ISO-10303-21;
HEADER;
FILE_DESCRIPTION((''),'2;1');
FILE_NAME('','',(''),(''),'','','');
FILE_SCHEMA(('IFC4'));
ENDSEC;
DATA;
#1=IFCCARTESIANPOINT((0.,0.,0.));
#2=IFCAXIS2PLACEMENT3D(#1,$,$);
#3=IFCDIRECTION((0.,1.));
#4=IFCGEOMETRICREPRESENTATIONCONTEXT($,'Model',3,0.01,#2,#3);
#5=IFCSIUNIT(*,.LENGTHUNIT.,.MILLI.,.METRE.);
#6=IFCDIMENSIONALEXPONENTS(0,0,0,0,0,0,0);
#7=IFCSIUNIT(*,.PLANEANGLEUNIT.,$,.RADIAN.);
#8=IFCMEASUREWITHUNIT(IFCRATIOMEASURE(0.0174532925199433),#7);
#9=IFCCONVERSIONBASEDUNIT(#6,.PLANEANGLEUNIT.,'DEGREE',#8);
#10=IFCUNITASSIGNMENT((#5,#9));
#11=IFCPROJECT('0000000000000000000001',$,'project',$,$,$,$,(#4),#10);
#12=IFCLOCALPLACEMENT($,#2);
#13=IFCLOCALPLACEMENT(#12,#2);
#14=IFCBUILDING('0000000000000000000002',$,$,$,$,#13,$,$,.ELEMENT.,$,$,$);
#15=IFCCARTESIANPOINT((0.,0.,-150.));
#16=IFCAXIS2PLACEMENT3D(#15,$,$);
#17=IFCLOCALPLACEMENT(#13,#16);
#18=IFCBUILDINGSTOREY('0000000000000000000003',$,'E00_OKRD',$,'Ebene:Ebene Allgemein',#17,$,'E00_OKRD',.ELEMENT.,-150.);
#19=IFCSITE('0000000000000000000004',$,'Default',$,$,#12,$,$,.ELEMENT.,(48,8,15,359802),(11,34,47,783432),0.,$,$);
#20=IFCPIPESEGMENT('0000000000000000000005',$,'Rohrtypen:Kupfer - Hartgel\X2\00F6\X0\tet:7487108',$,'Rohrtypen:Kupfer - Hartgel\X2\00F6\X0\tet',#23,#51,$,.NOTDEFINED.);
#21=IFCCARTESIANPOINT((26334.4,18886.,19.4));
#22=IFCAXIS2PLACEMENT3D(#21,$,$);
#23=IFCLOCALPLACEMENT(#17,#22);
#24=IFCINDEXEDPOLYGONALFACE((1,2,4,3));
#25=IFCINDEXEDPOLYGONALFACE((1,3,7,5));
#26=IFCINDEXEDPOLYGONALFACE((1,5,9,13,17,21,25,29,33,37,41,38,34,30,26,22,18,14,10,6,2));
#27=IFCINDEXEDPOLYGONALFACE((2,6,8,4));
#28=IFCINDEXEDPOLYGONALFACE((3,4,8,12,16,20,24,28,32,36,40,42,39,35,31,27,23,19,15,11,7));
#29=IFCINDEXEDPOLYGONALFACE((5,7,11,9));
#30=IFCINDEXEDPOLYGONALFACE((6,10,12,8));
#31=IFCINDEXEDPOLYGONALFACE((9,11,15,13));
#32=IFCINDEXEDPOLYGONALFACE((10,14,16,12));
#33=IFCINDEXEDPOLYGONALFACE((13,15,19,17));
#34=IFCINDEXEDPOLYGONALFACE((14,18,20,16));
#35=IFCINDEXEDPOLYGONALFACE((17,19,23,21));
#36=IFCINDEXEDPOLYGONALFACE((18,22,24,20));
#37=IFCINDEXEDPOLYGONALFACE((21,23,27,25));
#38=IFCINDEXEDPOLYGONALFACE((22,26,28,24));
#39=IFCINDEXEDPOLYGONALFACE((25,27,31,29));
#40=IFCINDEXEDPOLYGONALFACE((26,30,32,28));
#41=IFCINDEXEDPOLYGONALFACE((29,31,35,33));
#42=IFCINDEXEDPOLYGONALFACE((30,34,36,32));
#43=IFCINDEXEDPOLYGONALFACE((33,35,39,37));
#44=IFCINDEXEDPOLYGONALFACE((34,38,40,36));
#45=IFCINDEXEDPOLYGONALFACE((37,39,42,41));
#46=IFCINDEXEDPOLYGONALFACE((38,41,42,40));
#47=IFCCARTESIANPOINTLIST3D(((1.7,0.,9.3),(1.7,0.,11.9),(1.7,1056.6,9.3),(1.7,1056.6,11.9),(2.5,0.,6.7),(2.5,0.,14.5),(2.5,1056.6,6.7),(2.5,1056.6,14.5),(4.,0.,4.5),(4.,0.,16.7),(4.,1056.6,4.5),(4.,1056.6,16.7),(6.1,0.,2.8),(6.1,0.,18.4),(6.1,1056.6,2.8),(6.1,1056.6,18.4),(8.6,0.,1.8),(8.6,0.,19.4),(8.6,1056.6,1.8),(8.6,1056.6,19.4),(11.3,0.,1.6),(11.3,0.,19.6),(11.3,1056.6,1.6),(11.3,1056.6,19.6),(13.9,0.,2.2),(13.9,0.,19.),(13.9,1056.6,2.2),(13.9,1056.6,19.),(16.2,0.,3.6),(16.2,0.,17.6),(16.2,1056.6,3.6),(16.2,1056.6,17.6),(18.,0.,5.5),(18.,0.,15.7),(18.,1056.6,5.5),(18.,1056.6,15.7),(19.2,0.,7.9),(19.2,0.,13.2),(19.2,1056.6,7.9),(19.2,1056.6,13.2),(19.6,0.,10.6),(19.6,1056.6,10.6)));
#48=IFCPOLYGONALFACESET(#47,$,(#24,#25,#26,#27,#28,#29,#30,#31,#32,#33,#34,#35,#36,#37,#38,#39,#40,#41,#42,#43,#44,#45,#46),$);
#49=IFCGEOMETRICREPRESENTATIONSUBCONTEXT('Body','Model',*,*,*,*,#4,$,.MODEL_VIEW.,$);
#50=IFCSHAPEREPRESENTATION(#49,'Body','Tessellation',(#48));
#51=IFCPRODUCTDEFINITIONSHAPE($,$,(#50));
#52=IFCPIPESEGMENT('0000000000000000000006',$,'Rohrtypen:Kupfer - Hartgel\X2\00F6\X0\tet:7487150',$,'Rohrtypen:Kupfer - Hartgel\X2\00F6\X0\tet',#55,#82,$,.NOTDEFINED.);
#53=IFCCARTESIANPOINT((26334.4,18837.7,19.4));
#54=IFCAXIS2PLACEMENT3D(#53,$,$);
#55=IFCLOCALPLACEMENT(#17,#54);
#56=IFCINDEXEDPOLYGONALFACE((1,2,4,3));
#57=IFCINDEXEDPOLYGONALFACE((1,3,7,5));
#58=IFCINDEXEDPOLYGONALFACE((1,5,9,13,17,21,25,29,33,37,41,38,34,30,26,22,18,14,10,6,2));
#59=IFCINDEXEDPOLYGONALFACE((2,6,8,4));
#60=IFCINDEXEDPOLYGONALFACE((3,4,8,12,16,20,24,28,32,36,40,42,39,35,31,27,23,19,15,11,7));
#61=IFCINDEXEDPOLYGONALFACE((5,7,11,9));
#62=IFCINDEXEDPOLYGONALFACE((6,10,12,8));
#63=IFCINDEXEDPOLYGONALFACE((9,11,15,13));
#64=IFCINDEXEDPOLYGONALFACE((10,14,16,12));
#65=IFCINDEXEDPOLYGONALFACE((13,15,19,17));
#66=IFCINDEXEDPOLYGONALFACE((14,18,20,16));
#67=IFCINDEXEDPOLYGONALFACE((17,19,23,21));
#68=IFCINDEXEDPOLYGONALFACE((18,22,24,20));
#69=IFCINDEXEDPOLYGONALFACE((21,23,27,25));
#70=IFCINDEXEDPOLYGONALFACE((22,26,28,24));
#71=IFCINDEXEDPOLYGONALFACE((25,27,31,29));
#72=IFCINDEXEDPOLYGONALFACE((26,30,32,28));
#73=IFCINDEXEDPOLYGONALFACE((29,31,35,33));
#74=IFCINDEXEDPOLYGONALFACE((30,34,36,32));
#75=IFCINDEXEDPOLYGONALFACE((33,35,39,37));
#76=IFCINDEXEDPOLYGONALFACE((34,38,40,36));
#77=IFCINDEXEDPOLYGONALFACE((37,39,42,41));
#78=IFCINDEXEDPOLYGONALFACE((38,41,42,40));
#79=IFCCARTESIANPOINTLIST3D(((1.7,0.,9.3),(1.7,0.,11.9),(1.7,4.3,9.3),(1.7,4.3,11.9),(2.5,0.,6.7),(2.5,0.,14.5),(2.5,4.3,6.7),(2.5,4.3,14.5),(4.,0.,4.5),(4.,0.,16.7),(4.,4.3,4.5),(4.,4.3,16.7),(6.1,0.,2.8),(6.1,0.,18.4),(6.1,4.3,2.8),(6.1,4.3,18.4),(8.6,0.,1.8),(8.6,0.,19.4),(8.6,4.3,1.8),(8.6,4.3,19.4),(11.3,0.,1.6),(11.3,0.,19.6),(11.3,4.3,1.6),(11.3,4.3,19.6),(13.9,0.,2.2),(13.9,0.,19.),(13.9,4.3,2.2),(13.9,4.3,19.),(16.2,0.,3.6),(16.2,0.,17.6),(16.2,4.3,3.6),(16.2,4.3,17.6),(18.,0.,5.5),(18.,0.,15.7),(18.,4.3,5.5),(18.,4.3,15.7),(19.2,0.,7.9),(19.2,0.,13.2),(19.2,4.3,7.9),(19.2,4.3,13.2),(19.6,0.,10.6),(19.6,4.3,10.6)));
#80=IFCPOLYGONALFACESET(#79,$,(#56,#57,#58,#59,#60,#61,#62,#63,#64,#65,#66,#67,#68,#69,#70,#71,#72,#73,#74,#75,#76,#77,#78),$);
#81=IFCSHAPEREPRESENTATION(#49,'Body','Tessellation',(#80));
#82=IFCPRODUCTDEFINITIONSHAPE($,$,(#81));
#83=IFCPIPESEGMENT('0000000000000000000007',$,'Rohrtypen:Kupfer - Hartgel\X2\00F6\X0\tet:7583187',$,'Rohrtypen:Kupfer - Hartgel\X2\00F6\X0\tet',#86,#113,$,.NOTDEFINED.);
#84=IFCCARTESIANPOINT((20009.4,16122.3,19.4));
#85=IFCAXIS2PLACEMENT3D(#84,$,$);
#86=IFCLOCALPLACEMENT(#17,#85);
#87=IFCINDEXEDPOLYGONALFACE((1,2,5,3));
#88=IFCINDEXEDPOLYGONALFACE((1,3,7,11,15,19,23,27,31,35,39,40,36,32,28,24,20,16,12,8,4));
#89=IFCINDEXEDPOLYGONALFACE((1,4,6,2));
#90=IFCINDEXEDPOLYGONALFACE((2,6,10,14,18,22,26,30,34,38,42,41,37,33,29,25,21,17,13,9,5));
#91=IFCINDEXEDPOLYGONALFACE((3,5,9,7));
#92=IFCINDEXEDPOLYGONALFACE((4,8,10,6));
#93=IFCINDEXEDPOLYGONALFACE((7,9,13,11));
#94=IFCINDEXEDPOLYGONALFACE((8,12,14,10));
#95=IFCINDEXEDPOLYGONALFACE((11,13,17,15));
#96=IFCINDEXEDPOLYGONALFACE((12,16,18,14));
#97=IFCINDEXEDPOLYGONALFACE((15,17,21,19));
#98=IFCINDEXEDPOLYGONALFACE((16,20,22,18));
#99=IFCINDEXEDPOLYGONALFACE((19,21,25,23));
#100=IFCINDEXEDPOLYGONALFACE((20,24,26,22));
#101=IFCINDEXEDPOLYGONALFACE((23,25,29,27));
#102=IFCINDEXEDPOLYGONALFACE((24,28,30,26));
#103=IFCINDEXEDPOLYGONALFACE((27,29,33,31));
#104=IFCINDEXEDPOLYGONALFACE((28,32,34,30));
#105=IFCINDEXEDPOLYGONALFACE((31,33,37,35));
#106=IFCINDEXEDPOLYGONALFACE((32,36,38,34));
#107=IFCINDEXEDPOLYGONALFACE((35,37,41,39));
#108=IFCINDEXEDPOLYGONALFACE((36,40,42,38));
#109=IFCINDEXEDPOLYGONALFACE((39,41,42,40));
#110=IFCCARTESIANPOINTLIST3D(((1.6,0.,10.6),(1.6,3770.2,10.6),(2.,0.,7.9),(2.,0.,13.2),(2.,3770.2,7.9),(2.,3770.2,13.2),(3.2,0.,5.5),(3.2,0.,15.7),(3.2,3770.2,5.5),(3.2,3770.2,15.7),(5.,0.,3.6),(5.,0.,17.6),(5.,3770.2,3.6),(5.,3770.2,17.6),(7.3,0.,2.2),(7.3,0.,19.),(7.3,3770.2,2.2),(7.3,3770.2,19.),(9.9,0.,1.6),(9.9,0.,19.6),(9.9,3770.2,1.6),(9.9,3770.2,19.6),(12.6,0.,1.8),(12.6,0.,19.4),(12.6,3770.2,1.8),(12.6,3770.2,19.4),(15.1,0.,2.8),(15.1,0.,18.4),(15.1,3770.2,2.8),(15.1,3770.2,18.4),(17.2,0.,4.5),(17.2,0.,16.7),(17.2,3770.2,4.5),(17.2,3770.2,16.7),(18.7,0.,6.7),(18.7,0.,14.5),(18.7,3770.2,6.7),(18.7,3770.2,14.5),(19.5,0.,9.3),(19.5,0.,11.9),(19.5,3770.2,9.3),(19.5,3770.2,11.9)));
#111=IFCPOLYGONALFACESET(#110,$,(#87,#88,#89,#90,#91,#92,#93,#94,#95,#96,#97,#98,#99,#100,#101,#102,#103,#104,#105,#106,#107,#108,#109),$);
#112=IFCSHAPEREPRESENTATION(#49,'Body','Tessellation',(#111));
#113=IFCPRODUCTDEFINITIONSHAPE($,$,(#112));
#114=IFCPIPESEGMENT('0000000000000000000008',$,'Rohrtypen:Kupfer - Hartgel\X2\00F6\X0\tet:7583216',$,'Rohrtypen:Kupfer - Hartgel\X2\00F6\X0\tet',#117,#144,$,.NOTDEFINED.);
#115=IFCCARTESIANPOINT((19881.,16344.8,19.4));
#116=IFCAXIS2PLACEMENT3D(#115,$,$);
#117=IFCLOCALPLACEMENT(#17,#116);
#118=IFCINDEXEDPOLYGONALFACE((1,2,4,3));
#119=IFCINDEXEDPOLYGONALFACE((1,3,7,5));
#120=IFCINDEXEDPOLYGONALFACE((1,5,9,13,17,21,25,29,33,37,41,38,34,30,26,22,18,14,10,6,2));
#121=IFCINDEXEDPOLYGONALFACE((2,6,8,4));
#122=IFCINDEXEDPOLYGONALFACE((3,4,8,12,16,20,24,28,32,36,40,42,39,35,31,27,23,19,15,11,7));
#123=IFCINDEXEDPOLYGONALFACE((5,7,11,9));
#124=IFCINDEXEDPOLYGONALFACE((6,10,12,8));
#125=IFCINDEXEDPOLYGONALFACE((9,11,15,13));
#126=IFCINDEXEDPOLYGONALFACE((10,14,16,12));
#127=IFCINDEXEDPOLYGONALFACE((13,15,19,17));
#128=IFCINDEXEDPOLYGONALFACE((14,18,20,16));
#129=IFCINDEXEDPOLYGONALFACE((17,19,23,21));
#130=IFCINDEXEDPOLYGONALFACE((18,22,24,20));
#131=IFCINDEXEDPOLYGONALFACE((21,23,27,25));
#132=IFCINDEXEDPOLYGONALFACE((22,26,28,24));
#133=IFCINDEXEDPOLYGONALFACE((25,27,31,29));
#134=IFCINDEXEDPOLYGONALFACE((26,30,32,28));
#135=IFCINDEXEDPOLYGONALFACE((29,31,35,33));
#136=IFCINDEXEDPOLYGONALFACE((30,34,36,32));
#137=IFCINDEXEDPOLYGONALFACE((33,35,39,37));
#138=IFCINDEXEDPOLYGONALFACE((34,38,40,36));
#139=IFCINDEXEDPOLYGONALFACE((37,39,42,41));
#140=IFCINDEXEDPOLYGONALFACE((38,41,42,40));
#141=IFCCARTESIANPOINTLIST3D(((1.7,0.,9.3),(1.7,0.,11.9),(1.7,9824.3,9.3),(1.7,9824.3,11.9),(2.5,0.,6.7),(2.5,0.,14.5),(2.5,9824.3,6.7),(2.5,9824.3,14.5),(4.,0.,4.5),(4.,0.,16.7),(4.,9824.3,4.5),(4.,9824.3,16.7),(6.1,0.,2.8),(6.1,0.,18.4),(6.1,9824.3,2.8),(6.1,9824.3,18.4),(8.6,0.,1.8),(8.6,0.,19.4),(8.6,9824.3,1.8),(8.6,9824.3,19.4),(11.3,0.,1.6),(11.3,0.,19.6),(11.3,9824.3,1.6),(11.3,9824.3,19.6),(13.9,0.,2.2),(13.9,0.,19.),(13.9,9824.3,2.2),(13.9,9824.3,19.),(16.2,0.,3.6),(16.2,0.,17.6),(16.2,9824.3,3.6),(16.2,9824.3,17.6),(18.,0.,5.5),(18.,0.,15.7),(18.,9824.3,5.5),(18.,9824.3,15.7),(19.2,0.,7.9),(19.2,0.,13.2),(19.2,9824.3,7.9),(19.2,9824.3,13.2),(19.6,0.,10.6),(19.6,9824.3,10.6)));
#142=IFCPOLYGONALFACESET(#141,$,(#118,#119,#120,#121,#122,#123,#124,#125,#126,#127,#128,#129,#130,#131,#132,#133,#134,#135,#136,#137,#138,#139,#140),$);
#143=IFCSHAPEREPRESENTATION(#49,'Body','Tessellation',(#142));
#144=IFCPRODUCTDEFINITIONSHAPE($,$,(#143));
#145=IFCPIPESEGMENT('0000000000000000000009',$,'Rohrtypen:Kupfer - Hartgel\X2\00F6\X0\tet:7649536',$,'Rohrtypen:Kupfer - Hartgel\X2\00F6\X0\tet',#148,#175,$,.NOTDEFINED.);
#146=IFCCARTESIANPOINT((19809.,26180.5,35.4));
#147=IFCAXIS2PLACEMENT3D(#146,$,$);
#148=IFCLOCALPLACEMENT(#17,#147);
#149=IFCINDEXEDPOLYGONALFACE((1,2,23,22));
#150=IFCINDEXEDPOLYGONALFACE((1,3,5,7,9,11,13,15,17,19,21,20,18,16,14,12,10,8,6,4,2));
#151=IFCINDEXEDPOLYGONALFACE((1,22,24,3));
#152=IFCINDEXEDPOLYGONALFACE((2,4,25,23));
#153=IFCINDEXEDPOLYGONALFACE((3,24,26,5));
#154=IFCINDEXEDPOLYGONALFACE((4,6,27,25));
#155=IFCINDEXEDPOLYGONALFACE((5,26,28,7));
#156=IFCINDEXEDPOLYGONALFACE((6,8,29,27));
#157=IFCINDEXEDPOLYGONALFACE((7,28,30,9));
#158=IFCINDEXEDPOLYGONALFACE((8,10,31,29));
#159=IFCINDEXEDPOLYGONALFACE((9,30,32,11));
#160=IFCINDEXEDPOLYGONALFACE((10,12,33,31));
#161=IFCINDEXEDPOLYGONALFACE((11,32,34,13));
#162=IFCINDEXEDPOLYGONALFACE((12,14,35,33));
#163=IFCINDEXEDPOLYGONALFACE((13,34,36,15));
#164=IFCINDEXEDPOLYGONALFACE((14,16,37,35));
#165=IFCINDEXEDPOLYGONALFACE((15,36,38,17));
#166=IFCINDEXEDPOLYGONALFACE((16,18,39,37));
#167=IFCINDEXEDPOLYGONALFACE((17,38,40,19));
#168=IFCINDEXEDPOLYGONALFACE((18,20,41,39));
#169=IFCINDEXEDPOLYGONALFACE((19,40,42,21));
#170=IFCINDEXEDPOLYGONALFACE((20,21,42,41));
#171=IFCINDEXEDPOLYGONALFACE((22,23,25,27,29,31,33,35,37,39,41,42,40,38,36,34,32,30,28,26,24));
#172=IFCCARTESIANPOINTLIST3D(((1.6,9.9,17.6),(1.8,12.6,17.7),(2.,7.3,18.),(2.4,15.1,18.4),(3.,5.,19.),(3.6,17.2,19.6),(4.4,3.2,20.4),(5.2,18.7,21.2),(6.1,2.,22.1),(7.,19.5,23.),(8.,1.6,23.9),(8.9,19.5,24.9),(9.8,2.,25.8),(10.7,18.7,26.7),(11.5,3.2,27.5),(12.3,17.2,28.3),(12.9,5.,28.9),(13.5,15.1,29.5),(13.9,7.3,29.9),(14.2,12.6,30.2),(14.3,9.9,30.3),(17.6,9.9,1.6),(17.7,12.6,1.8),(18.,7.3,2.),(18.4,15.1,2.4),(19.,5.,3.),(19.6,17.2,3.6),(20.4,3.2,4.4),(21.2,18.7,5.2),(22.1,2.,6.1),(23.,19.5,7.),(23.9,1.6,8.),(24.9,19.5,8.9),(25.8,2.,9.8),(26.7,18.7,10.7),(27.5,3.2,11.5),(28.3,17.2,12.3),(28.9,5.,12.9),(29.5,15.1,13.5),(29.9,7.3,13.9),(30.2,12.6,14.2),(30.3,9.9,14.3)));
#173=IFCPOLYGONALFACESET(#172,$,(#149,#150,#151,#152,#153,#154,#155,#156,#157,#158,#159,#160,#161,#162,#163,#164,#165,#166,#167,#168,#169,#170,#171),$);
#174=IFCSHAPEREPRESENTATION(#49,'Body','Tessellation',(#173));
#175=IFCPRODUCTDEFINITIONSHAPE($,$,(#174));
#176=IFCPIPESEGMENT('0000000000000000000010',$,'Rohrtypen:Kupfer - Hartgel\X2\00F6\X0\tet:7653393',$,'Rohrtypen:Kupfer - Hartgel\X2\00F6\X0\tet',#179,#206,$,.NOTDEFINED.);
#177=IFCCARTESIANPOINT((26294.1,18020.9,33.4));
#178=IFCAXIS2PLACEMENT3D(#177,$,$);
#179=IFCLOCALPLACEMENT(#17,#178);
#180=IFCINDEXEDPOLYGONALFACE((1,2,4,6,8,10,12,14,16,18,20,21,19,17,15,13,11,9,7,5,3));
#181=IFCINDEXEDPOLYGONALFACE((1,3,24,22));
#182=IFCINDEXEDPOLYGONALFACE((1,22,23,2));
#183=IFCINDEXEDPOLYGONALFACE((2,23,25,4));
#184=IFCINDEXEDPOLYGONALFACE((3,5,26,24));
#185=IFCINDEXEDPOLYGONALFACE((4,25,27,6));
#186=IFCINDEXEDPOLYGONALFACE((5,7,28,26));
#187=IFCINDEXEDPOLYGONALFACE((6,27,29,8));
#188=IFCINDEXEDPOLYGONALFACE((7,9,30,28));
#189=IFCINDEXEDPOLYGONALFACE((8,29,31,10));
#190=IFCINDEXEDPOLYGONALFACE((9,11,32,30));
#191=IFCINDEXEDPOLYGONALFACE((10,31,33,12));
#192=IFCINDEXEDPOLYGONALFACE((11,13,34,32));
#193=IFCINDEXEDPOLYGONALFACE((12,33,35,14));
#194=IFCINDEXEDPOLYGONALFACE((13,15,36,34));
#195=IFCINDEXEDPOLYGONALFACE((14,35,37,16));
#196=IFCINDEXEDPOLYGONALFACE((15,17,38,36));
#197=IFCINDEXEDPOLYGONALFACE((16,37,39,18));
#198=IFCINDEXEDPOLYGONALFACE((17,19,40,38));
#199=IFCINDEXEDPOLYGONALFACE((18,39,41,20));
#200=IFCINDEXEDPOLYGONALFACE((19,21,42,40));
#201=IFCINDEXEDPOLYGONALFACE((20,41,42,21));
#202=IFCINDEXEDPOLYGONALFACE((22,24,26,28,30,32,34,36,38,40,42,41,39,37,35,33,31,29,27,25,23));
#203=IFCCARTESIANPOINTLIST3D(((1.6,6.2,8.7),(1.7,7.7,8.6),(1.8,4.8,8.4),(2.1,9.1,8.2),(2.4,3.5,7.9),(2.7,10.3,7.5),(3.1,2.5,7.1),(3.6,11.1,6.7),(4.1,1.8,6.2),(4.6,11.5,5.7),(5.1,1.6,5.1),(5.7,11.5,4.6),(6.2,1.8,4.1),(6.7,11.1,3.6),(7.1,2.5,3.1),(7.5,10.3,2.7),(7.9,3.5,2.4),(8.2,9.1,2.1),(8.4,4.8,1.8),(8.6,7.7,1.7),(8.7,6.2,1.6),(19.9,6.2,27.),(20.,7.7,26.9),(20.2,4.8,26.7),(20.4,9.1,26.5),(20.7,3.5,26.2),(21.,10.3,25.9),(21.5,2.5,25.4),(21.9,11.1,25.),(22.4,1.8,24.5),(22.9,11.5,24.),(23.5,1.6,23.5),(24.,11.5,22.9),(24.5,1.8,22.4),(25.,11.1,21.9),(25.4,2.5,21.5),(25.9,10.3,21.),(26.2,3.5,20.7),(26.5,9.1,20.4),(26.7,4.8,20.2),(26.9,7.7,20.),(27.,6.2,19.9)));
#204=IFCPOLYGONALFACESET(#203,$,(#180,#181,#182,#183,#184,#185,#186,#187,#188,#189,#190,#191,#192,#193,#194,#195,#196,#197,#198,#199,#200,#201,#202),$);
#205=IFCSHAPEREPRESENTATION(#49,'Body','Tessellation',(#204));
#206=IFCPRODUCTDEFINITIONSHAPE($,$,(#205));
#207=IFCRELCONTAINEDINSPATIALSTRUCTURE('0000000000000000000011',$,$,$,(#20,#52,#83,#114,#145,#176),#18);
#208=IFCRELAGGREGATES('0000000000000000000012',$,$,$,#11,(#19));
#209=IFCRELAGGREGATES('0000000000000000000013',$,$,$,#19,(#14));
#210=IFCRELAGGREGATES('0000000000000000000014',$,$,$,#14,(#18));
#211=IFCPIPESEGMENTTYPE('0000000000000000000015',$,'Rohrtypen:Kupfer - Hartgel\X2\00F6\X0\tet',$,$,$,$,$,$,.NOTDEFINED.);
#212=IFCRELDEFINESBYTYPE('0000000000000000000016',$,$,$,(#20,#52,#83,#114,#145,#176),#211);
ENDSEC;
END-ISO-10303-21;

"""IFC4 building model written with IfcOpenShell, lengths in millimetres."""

from ifc_helpers import new_model, entity, si_unit, converted_unit, direction, frame, frame_2d, origin, origin_2d_with_axis, place, context, subcontext, project, spatial, circle, extrude, type_object, element, save


model = new_model("IFC4")

# Units and contexts
model_context = context("Model", 3, precision=0.01, world=origin(), true_north=direction((0.0, 1.0)))
body_context = subcontext(model_context, "Body", "Model", "MODEL_VIEW")
ifc_project = project(units=[si_unit("LENGTHUNIT", "METRE", prefix="MILLI"), converted_unit("PLANEANGLEUNIT", "DEGREE", entity("IfcRatioMeasure", 0.0174532925199433), si_unit("PLANEANGLEUNIT", "RADIAN"), dimensions=[0, 0, 0, 0, 0, 0, 0])], contexts=[model_context])

# Site, building, storey
site_placement = place(None, origin())
site = spatial("IfcSite", under=ifc_project, at=site_placement, Name="Default", CompositionType="ELEMENT", RefLatitude=(48, 8, 15, 359802), RefLongitude=(11, 34, 47, 783432), RefElevation=0.0)
building_placement = place(site_placement, origin())
building = spatial("IfcBuilding", under=site, at=building_placement, CompositionType="ELEMENT")
storey_placement = place(building_placement, frame((0.0, 0.0, -150.0)))
storey = spatial("IfcBuildingStorey", under=building, at=storey_placement, Name="E00_OKRD", ObjectType="Ebene:Ebene Allgemein", LongName="E00_OKRD", CompositionType="ELEMENT", Elevation=-150.0)

# Pipe segments
pipe_segment_type = type_object("IfcPipeSegmentType", Name="Rohrtypen:Kupfer - Hartgelötet", PredefinedType="NOTDEFINED")
pipe_segment_1_placement = place(storey_placement, frame((26334.4, 18886.0, 19.4)))
element("IfcPipeSegment", 1, at=pipe_segment_1_placement, inside=storey, type_object=pipe_segment_type, Name="Rohrtypen:Kupfer - Hartgelötet:7487108", ObjectType="Rohrtypen:Kupfer - Hartgelötet", PredefinedType="NOTDEFINED", context=body_context, shape_type="SweptSolid", body=[
    extrude(circle(Radius=9.0, at=origin_2d_with_axis()), frame((10.6, 0.0, 10.6), z_axis=(0.0, 1.0, 0.0), x_axis=(1.0, 0.0, 0.0)), (0.0, 0.0, 1.0), 1056.6),
])
pipe_segment_2_placement = place(storey_placement, frame((26334.4, 18837.7, 19.4)))
element("IfcPipeSegment", 2, at=pipe_segment_2_placement, inside=storey, type_object=pipe_segment_type, Name="Rohrtypen:Kupfer - Hartgelötet:7487150", ObjectType="Rohrtypen:Kupfer - Hartgelötet", PredefinedType="NOTDEFINED", context=body_context, shape_type="SweptSolid", body=[
    extrude(circle(Radius=9.0, at=origin_2d_with_axis()), frame((10.6, 0.0, 10.6), z_axis=(0.0, 1.0, 0.0), x_axis=(1.0, 0.0, 0.0)), (0.0, 0.0, 1.0), 4.3),
])
pipe_segment_3_placement = place(storey_placement, frame((20009.4, 16122.3, 19.4)))
element("IfcPipeSegment", 3, at=pipe_segment_3_placement, inside=storey, type_object=pipe_segment_type, Name="Rohrtypen:Kupfer - Hartgelötet:7583187", ObjectType="Rohrtypen:Kupfer - Hartgelötet", PredefinedType="NOTDEFINED", context=body_context, shape_type="SweptSolid", body=[
    extrude(circle(Radius=9.0, at=frame_2d((0.0, 0.0), x_axis=(1.0, 0.0))), frame((10.6, 0.0, 10.6), z_axis=(0.0, 1.0, 0.0), x_axis=(-1.0, 0.0, 0.0)), (0.0, 0.0, 1.0), 3770.2),
])
pipe_segment_4_placement = place(storey_placement, frame((19881.0, 16344.8, 19.4)))
element("IfcPipeSegment", 4, at=pipe_segment_4_placement, inside=storey, type_object=pipe_segment_type, Name="Rohrtypen:Kupfer - Hartgelötet:7583216", ObjectType="Rohrtypen:Kupfer - Hartgelötet", PredefinedType="NOTDEFINED", context=body_context, shape_type="SweptSolid", body=[
    extrude(circle(Radius=9.0, at=frame_2d((0.0, 0.0), x_axis=(1.0, 0.0))), frame((10.6, 0.0, 10.6), z_axis=(0.0, 1.0, 0.0), x_axis=(1.0, 0.0, 0.0)), (0.0, 0.0, 1.0), 9824.3),
])
pipe_segment_5_placement = place(storey_placement, frame((19809.0, 26180.5, 35.4)))
element("IfcPipeSegment", 5, at=pipe_segment_5_placement, inside=storey, type_object=pipe_segment_type, Name="Rohrtypen:Kupfer - Hartgelötet:7649536", ObjectType="Rohrtypen:Kupfer - Hartgelötet", PredefinedType="NOTDEFINED", context=body_context, shape_type="SweptSolid", body=[
    extrude(circle(Radius=9.0, at=origin_2d_with_axis()), frame((8.0, 10.6, 23.9), z_axis=(0.707107, 0.0, -0.707107), x_axis=(0.0, -1.0, 0.0)), (0.0, 0.0, 1.0), 22.6),
])
pipe_segment_6_placement = place(storey_placement, frame((26294.1, 18020.9, 33.4)))
element("IfcPipeSegment", 6, at=pipe_segment_6_placement, inside=storey, type_object=pipe_segment_type, Name="Rohrtypen:Kupfer - Hartgelötet:7653393", ObjectType="Rohrtypen:Kupfer - Hartgelötet", PredefinedType="NOTDEFINED", context=body_context, shape_type="SweptSolid", body=[
    extrude(circle(Radius=5.0, at=frame_2d((0.0, 0.0), x_axis=(1.0, 0.0))), frame((5.1, 6.6, 5.1), z_axis=(0.707107, 0.0, 0.707107), x_axis=(0.0, -1.0, 0.0)), (0.0, 0.0, 1.0), 25.9),
])

save(model, "model.ifc")
